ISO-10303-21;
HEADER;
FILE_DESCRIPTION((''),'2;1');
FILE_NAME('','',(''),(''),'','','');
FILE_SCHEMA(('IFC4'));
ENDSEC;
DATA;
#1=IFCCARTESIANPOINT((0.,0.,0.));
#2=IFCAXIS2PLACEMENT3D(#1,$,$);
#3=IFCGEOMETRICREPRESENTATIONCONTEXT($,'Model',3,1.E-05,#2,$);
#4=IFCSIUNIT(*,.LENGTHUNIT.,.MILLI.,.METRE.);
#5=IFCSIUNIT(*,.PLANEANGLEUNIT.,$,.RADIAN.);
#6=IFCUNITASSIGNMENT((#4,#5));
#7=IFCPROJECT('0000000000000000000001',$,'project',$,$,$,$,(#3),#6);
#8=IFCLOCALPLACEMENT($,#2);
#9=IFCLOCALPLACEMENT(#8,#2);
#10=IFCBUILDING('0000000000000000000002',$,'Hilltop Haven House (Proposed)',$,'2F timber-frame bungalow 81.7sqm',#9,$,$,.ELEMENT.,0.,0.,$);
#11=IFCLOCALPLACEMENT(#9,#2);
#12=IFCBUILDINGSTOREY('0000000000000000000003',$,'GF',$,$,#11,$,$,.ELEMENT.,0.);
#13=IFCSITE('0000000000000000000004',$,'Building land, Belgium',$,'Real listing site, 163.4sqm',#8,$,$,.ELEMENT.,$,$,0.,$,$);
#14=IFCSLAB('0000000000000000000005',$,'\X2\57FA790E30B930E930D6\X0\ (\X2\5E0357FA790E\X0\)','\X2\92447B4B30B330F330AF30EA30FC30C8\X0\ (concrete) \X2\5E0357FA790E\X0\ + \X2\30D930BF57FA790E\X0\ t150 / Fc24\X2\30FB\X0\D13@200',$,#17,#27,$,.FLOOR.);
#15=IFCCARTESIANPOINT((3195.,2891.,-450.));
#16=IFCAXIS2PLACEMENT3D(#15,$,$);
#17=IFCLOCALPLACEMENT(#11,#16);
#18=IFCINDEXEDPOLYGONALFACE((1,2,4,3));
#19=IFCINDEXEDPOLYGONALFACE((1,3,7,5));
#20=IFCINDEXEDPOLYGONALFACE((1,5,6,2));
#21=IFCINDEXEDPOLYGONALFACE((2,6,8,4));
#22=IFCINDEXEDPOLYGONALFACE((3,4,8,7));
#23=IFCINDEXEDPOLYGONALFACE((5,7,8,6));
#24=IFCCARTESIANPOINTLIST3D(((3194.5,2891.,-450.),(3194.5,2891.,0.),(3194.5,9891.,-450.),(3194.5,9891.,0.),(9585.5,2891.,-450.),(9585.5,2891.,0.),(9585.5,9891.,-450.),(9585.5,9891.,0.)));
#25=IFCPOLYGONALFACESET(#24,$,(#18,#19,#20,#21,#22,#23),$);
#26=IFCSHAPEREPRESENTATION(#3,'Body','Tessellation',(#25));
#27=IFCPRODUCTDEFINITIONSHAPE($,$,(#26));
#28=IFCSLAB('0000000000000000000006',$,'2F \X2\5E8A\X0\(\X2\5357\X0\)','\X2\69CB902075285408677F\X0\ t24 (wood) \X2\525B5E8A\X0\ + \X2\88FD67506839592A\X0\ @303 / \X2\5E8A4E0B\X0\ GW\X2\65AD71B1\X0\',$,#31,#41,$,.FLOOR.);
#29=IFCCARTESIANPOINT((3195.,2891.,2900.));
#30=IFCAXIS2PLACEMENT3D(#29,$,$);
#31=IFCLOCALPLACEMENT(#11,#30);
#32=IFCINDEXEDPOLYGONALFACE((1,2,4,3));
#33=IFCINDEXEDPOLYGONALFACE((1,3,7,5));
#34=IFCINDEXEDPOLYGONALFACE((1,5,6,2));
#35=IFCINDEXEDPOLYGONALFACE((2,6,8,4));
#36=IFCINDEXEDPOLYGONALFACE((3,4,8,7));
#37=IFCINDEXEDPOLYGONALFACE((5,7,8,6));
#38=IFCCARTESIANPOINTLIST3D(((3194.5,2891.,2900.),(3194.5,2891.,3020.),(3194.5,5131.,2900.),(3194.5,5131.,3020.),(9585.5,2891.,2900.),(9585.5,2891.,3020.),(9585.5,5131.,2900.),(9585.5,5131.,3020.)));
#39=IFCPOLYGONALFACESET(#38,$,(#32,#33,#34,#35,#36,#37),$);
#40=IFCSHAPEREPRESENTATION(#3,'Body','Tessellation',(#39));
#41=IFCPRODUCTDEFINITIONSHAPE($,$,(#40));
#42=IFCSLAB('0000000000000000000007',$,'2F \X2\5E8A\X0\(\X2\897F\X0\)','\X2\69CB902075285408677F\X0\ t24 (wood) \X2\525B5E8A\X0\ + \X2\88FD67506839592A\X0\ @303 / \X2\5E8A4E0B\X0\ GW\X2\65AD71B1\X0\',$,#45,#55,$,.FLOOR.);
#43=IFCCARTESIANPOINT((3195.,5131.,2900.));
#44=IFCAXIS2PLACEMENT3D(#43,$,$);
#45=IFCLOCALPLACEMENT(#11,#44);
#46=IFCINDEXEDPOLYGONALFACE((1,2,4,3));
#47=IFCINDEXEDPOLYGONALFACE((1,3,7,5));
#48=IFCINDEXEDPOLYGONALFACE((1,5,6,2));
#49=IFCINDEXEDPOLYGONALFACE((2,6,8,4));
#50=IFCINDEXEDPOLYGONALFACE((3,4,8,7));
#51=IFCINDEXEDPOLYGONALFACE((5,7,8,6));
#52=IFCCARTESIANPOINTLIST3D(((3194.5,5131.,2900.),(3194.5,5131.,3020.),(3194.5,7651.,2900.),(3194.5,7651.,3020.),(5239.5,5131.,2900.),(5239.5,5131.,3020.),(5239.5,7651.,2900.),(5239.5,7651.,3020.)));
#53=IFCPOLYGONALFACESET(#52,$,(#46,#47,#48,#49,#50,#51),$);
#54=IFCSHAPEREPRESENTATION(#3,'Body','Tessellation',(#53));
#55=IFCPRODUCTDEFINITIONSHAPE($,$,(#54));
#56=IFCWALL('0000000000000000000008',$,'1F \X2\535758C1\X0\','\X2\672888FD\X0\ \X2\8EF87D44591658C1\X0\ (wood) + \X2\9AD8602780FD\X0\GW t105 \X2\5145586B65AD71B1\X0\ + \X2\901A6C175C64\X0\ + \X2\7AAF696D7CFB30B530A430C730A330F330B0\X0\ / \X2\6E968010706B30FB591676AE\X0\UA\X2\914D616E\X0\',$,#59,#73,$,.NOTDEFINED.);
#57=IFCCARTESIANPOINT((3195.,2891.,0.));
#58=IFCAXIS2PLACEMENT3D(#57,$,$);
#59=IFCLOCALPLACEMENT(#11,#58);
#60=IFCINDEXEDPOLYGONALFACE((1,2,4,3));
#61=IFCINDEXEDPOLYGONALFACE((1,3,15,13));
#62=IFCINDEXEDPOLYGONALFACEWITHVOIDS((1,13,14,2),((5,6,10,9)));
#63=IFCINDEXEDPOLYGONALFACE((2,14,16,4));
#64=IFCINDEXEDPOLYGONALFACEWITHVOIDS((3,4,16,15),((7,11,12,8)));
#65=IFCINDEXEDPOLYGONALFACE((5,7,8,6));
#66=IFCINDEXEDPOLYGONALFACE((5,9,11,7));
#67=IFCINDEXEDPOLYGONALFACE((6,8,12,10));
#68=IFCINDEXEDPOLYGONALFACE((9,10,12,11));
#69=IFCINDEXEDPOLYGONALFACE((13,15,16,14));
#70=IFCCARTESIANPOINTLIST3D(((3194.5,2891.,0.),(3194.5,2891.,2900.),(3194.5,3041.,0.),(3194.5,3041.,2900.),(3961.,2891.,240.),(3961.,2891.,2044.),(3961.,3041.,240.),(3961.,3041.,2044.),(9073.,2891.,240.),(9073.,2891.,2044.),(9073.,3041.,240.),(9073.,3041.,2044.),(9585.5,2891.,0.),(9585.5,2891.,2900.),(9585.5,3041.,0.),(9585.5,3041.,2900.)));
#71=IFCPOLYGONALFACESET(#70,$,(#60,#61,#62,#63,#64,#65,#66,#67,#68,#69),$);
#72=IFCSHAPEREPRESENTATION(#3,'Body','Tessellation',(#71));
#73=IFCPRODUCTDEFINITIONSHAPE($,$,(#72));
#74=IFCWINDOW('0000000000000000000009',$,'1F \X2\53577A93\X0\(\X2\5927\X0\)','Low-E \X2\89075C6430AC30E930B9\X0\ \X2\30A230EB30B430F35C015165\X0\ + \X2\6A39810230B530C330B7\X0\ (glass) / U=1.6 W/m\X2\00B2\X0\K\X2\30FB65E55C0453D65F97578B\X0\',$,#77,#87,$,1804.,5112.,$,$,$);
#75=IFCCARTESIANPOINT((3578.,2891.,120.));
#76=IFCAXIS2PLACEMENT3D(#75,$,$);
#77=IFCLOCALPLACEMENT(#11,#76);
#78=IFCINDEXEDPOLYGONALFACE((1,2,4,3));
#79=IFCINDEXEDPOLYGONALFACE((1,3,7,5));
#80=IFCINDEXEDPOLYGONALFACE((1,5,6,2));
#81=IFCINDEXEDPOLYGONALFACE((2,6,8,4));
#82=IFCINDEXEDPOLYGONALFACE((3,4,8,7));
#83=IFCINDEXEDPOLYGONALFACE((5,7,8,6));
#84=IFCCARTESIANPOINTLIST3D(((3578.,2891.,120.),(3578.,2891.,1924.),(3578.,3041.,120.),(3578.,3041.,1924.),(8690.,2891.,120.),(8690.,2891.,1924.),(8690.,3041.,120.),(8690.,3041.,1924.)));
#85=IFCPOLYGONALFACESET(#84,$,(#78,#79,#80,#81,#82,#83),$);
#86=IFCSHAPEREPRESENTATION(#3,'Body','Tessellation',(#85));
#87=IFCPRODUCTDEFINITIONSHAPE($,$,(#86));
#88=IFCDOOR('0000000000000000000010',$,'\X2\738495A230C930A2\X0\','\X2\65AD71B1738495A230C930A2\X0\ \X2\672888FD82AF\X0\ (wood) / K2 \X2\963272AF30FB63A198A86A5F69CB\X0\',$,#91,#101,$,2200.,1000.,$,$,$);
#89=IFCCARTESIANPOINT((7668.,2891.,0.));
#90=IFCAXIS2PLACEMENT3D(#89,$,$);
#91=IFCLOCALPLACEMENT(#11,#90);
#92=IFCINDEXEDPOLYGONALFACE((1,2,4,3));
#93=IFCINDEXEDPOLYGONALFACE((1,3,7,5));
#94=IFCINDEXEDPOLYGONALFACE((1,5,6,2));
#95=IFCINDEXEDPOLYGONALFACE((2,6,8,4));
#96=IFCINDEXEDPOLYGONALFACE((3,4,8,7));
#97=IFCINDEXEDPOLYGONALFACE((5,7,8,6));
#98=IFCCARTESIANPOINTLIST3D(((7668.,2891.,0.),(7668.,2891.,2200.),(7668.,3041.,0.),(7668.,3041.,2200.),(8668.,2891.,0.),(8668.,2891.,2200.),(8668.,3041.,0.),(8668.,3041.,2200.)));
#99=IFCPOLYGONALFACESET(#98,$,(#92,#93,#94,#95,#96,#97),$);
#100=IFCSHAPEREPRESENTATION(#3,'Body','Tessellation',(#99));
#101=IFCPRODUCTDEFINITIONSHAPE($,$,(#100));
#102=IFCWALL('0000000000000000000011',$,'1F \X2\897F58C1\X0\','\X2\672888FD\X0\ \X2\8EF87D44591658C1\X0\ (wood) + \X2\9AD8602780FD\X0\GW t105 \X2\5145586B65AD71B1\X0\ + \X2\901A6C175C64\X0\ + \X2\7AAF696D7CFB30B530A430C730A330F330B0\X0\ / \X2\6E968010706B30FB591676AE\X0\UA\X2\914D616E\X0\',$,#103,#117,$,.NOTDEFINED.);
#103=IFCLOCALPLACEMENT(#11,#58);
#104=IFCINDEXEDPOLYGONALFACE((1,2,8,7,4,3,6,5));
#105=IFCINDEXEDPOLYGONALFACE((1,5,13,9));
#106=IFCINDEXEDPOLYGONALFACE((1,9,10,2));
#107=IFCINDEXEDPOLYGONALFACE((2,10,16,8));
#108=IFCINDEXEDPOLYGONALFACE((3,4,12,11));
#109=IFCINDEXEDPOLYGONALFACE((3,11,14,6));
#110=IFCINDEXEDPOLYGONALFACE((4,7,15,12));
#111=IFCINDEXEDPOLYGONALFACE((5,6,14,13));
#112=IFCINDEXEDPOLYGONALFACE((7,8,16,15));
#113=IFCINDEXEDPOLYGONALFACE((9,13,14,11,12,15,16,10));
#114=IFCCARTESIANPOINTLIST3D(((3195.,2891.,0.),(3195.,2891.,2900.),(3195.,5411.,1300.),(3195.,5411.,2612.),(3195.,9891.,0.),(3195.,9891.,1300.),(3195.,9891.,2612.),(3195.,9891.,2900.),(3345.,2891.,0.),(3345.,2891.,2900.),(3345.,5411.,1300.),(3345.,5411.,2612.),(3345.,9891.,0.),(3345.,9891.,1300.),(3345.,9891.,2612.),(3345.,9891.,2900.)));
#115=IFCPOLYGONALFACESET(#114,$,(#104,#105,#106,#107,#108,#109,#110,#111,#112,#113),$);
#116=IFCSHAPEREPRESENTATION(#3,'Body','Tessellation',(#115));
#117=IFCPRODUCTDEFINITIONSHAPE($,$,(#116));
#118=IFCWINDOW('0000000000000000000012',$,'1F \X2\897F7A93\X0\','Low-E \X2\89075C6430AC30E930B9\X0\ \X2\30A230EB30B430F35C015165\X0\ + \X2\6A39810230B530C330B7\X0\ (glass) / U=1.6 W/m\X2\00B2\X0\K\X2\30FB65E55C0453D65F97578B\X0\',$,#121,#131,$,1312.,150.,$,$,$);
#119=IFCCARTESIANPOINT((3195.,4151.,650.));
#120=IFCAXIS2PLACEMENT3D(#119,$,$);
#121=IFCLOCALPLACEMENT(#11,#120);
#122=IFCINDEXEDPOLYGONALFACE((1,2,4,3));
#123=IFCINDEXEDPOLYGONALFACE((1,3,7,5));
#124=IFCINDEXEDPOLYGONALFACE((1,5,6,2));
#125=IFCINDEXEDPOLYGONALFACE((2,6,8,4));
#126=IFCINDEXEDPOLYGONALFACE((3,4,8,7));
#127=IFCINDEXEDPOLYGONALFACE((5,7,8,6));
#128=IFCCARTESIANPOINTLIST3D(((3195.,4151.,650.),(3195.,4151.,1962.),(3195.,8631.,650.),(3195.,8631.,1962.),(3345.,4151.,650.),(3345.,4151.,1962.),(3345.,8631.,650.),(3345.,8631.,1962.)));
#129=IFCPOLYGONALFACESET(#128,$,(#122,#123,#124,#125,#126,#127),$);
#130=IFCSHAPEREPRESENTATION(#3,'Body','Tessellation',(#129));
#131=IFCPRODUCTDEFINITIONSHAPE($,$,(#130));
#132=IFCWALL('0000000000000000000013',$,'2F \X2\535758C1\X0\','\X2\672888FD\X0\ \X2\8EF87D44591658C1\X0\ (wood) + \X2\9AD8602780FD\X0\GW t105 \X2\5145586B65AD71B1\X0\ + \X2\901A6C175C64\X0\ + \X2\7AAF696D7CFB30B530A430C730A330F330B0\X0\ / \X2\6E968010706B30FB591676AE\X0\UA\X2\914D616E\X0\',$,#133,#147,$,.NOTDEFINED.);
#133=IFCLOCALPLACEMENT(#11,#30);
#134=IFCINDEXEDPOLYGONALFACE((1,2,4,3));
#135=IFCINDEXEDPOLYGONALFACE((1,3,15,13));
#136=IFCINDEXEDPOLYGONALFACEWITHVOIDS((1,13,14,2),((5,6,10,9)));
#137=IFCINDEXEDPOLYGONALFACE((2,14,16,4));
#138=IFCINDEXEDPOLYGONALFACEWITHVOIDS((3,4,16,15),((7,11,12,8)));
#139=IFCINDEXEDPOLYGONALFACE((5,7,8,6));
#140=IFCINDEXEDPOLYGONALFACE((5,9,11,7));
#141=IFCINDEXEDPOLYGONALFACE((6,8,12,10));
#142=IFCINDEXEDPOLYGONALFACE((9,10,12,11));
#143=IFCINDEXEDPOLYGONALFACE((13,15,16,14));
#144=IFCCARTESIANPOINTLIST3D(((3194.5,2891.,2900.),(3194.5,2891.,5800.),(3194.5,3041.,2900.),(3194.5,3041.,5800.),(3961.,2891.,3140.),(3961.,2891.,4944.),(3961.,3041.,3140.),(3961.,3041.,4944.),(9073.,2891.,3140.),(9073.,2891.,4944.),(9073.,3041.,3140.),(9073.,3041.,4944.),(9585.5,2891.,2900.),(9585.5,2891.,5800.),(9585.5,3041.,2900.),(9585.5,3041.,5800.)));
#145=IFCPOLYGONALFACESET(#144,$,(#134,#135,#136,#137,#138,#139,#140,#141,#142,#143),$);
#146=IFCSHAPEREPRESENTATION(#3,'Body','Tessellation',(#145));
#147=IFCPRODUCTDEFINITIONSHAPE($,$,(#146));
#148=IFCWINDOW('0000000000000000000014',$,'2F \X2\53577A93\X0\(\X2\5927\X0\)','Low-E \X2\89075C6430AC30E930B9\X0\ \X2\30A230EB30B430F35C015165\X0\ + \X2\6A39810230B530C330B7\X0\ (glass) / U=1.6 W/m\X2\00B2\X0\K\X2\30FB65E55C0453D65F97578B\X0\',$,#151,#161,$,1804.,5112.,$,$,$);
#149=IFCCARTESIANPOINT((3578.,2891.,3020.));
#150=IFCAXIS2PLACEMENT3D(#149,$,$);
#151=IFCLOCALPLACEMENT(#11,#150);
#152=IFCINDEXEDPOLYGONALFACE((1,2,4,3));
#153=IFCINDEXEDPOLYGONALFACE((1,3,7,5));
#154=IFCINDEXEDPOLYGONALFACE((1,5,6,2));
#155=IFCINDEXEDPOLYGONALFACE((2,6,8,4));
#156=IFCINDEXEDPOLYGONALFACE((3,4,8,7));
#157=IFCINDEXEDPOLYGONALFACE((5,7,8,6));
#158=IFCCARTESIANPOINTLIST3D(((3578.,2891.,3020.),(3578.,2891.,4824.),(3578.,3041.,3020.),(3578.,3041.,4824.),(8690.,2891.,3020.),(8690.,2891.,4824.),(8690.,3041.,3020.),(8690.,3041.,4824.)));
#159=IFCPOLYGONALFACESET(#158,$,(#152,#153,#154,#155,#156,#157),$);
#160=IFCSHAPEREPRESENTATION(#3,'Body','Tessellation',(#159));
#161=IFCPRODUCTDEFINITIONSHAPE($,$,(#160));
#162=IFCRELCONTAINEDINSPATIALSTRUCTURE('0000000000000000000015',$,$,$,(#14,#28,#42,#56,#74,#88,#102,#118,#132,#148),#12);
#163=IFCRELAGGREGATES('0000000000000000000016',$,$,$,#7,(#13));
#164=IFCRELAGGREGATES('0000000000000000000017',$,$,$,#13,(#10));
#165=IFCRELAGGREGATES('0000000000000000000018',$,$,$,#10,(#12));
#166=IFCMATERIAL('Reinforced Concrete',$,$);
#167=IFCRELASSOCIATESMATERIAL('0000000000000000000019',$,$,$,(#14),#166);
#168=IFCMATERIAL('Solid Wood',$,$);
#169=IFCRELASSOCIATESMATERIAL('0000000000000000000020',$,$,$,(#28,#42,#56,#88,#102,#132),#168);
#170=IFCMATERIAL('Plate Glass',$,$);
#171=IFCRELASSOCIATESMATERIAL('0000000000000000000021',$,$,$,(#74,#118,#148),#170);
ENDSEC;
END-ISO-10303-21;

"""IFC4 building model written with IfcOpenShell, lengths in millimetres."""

from ifc_helpers import new_model, si_unit, frame, frame_2d, origin, place, context, project, spatial, rectangle, extrude, material, element, fill, save


model = new_model("IFC4")

# Units and contexts
model_context = context("Model", 3, precision=1e-05, world=origin())
ifc_project = project(units=[si_unit("LENGTHUNIT", "METRE", prefix="MILLI"), si_unit("PLANEANGLEUNIT", "RADIAN")], contexts=[model_context])

# Site, building, storey
site_placement = place(None, origin())
site = spatial("IfcSite", under=ifc_project, at=site_placement, Name="Building land, Belgium", ObjectType="Real listing site, 163.4sqm", CompositionType="ELEMENT", RefElevation=0.0)
building_placement = place(site_placement, origin())
building = spatial("IfcBuilding", under=site, at=building_placement, Name="Hilltop Haven House (Proposed)", ObjectType="2F timber-frame bungalow 81.7sqm", CompositionType="ELEMENT", ElevationOfRefHeight=0.0, ElevationOfTerrain=0.0)
storey_placement = place(building_placement, origin())
storey = spatial("IfcBuildingStorey", under=building, at=storey_placement, Name="GF", CompositionType="ELEMENT", Elevation=0.0)

# Slabs
ifc_material_1 = material(Name="Reinforced Concrete")
slab_1_placement = place(storey_placement, frame((3195.0, 2891.0, -450.0)))
element("IfcSlab", 1, at=slab_1_placement, inside=storey, material=ifc_material_1, Name="基礎スラブ (布基礎)", Description="鉄筋コンクリート (concrete) 布基礎 + ベタ基礎 t150 / Fc24・D13@200", PredefinedType="FLOOR", context=model_context, shape_type="SweptSolid", body=[
    extrude(rectangle(XDim=6391.0, YDim=7000.0, at=frame_2d((3195.0, 3500.0))), frame((3195.0, 2891.0, -450.0)), (0.0, 0.0, 1.0), 450.0),
])
ifc_material_2 = material(Name="Solid Wood")
slab_2_placement = place(storey_placement, frame((3195.0, 2891.0, 2900.0)))
element("IfcSlab", 2, at=slab_2_placement, inside=storey, material=ifc_material_2, Name="2F 床(南)", Description="構造用合板 t24 (wood) 剛床 + 製材根太 @303 / 床下 GW断熱", PredefinedType="FLOOR", context=model_context, shape_type="SweptSolid", body=[
    extrude(rectangle(XDim=6391.0, YDim=2240.0, at=frame_2d((3195.0, 1120.0))), frame((3195.0, 2891.0, 2900.0)), (0.0, 0.0, 1.0), 120.0),
])
slab_3_placement = place(storey_placement, frame((3195.0, 5131.0, 2900.0)))
element("IfcSlab", 3, at=slab_3_placement, inside=storey, material=ifc_material_2, Name="2F 床(西)", Description="構造用合板 t24 (wood) 剛床 + 製材根太 @303 / 床下 GW断熱", PredefinedType="FLOOR", context=model_context, shape_type="SweptSolid", body=[
    extrude(rectangle(XDim=2045.0, YDim=2520.0, at=frame_2d((1022.0, 1260.0))), frame((3195.0, 5131.0, 2900.0)), (0.0, 0.0, 1.0), 120.0),
])

# Wall, openings, window, door
wall_1_placement = place(storey_placement, frame((3195.0, 2891.0, 0.0)))
wall_1 = element("IfcWall", 4, at=wall_1_placement, inside=storey, material=ifc_material_2, Name="1F 南壁", Description="木製 軸組外壁 (wood) + 高性能GW t105 充填断熱 + 通気層 + 窯業系サイディング / 準耐火・外皮UA配慮", PredefinedType="NOTDEFINED", context=model_context, shape_type="SweptSolid", body=[
    extrude(rectangle(XDim=6391.0, YDim=150.0, at=frame_2d((3195.0, 75.0))), frame((3195.0, 2891.0, 0.0)), (0.0, 0.0, 1.0), 2900.0),
])
opening_1_placement = place(storey_placement, frame((3578.0, 2891.0, 120.0)))
opening_1 = element("IfcOpeningElement", 5, at=opening_1_placement, cuts=wall_1, PredefinedType="NOTDEFINED", context=model_context, shape_type="SweptSolid", body=[
    extrude(rectangle(XDim=5112.0, YDim=150.0, at=frame_2d((2556.0, 75.0))), frame((3578.0, 2891.0, 120.0)), (0.0, 0.0, 1.0), 1804.0),
])
opening_2_placement = place(storey_placement, frame((7668.0, 2891.0, 0.0)))
opening_2 = element("IfcOpeningElement", 6, at=opening_2_placement, cuts=wall_1, PredefinedType="NOTDEFINED", context=model_context, shape_type="SweptSolid", body=[
    extrude(rectangle(XDim=1000.0, YDim=150.0, at=frame_2d((500.0, 75.0))), frame((7668.0, 2891.0, 0.0)), (0.0, 0.0, 1.0), 2200.0),
])
ifc_material_3 = material(Name="Plate Glass")
window_1_placement = place(storey_placement, frame((3578.0, 2891.0, 120.0)))
window_1 = element("IfcWindow", 7, at=window_1_placement, inside=storey, material=ifc_material_3, Name="1F 南窓(大)", Description="Low-E 複層ガラス アルゴン封入 + 樹脂サッシ (glass) / U=1.6 W/m²K・日射取得型", OverallHeight=1804.0, OverallWidth=5112.0, context=model_context, shape_type="SweptSolid", body=[
    extrude(rectangle(XDim=5112.0, YDim=150.0, at=frame_2d((2556.0, 75.0))), frame((3578.0, 2891.0, 120.0)), (0.0, 0.0, 1.0), 1804.0),
])
fill(opening_1, window_1)
door_placement = place(storey_placement, frame((7668.0, 2891.0, 0.0)))
door = element("IfcDoor", 8, at=door_placement, inside=storey, material=ifc_material_2, Name="玄関ドア", Description="断熱玄関ドア 木製芯 (wood) / K2 防犯・採風機構", OverallHeight=2200.0, OverallWidth=1000.0, context=model_context, shape_type="SweptSolid", body=[
    extrude(rectangle(XDim=1000.0, YDim=150.0, at=frame_2d((500.0, 75.0))), frame((7668.0, 2891.0, 0.0)), (0.0, 0.0, 1.0), 2200.0),
])
fill(opening_2, door)

# Walls, openings, windows
wall_2_placement = place(storey_placement, frame((3195.0, 2891.0, 0.0)))
wall_2 = element("IfcWall", 9, at=wall_2_placement, inside=storey, material=ifc_material_2, Name="1F 西壁", Description="木製 軸組外壁 (wood) + 高性能GW t105 充填断熱 + 通気層 + 窯業系サイディング / 準耐火・外皮UA配慮", PredefinedType="NOTDEFINED", context=model_context, shape_type="SweptSolid", body=[
    extrude(rectangle(XDim=150.0, YDim=7000.0, at=frame_2d((75.0, 3500.0))), frame((3195.0, 2891.0, 0.0)), (0.0, 0.0, 1.0), 2900.0),
])
opening_3_placement = place(storey_placement, frame((3195.0, 4151.0, 650.0)))
opening_3 = element("IfcOpeningElement", 10, at=opening_3_placement, cuts=wall_2, PredefinedType="NOTDEFINED", context=model_context, shape_type="SweptSolid", body=[
    extrude(rectangle(XDim=150.0, YDim=4480.0, at=frame_2d((75.0, 2240.0))), frame((3195.0, 4151.0, 650.0)), (0.0, 0.0, 1.0), 1312.0),
])
window_2_placement = place(storey_placement, frame((3195.0, 4151.0, 650.0)))
window_2 = element("IfcWindow", 11, at=window_2_placement, inside=storey, material=ifc_material_3, Name="1F 西窓", Description="Low-E 複層ガラス アルゴン封入 + 樹脂サッシ (glass) / U=1.6 W/m²K・日射取得型", OverallHeight=1312.0, OverallWidth=150.0, context=model_context, shape_type="SweptSolid", body=[
    extrude(rectangle(XDim=150.0, YDim=4480.0, at=frame_2d((75.0, 2240.0))), frame((3195.0, 4151.0, 650.0)), (0.0, 0.0, 1.0), 1312.0),
])
fill(opening_3, window_2)
wall_3_placement = place(storey_placement, frame((3195.0, 2891.0, 2900.0)))
wall_3 = element("IfcWall", 12, at=wall_3_placement, inside=storey, material=ifc_material_2, Name="2F 南壁", Description="木製 軸組外壁 (wood) + 高性能GW t105 充填断熱 + 通気層 + 窯業系サイディング / 準耐火・外皮UA配慮", PredefinedType="NOTDEFINED", context=model_context, shape_type="SweptSolid", body=[
    extrude(rectangle(XDim=6391.0, YDim=150.0, at=frame_2d((3195.0, 75.0))), frame((3195.0, 2891.0, 2900.0)), (0.0, 0.0, 1.0), 2900.0),
])
opening_4_placement = place(storey_placement, frame((3578.0, 2891.0, 3020.0)))
opening_4 = element("IfcOpeningElement", 13, at=opening_4_placement, cuts=wall_3, PredefinedType="NOTDEFINED", context=model_context, shape_type="SweptSolid", body=[
    extrude(rectangle(XDim=5112.0, YDim=150.0, at=frame_2d((2556.0, 75.0))), frame((3578.0, 2891.0, 3020.0)), (0.0, 0.0, 1.0), 1804.0),
])
window_3_placement = place(storey_placement, frame((3578.0, 2891.0, 3020.0)))
window_3 = element("IfcWindow", 14, at=window_3_placement, inside=storey, material=ifc_material_3, Name="2F 南窓(大)", Description="Low-E 複層ガラス アルゴン封入 + 樹脂サッシ (glass) / U=1.6 W/m²K・日射取得型", OverallHeight=1804.0, OverallWidth=5112.0, context=model_context, shape_type="SweptSolid", body=[
    extrude(rectangle(XDim=5112.0, YDim=150.0, at=frame_2d((2556.0, 75.0))), frame((3578.0, 2891.0, 3020.0)), (0.0, 0.0, 1.0), 1804.0),
])
fill(opening_4, window_3)

save(model, "model.ifc")
